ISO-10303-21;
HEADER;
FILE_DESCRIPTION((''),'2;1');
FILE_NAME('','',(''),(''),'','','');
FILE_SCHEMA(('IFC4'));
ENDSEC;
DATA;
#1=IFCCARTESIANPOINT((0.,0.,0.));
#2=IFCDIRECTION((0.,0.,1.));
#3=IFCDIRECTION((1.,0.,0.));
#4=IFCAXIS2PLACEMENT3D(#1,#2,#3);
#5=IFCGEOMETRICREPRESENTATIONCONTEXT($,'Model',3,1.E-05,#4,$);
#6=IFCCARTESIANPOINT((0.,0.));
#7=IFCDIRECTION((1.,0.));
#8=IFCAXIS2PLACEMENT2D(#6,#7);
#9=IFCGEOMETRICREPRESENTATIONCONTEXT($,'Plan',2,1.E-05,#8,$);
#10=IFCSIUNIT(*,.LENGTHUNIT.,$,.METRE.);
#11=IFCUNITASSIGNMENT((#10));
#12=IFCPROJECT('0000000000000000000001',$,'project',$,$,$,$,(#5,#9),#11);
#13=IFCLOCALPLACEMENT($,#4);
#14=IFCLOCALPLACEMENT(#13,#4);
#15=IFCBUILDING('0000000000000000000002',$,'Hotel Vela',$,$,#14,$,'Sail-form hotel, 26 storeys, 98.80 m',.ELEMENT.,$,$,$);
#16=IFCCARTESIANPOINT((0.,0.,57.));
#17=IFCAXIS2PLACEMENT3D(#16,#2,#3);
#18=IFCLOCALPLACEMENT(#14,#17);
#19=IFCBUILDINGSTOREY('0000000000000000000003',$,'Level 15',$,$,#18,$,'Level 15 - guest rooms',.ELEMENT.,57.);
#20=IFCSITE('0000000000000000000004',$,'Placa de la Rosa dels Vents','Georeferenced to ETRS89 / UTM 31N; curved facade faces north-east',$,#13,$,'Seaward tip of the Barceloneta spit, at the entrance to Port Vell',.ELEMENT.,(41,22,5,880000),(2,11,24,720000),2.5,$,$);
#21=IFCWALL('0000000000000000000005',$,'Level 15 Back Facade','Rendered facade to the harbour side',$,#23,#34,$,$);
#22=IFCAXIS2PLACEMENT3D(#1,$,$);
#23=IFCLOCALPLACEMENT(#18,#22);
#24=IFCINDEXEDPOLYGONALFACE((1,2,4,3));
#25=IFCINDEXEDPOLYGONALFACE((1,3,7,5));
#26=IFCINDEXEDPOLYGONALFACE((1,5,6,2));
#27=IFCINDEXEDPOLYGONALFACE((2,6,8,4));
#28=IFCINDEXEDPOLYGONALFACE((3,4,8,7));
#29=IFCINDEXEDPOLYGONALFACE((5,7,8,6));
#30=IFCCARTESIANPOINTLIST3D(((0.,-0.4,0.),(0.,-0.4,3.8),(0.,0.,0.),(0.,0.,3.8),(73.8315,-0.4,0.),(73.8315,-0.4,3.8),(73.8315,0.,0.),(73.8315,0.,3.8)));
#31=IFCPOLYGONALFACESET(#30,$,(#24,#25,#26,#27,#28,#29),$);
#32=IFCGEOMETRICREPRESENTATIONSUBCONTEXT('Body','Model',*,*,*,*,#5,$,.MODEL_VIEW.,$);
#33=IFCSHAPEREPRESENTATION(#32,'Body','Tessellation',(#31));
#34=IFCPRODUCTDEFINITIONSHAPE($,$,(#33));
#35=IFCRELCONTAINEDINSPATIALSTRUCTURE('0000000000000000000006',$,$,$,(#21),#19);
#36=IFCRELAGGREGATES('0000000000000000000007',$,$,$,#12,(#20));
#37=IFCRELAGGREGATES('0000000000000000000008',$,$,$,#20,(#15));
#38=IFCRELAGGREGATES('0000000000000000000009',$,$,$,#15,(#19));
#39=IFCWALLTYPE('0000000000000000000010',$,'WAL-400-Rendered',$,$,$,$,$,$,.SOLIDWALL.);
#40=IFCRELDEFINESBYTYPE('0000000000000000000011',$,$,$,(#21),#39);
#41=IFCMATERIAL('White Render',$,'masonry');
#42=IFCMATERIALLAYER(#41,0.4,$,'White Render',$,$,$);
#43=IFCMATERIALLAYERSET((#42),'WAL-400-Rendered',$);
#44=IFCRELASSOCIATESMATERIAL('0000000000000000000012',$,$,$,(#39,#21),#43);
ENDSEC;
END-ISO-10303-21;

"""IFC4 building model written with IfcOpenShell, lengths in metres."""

from ifc_helpers import new_model, si_unit, frame, origin_with_axes, origin_2d_with_axis, place, context, subcontext, project, spatial, line, indexed_curve, outline, extrude, material, layer, layer_set, layer_usage, type_object, element, save


model = new_model("IFC4")

# Units and contexts
model_context = context("Model", 3, precision=1e-05, world=origin_with_axes())
plan_context = context("Plan", 2, precision=1e-05, world=origin_2d_with_axis())
body_context = subcontext(model_context, "Body", "Model", "MODEL_VIEW")
ifc_project = project(units=[si_unit("LENGTHUNIT", "METRE")], contexts=[model_context, plan_context])

# Site, building, storey
site_placement = place(None, origin_with_axes())
site = spatial("IfcSite", under=ifc_project, at=site_placement, Name="Placa de la Rosa dels Vents", Description="Georeferenced to ETRS89 / UTM 31N; curved facade faces north-east", LongName="Seaward tip of the Barceloneta spit, at the entrance to Port Vell", CompositionType="ELEMENT", RefLatitude=(41, 22, 5, 880000), RefLongitude=(2, 11, 24, 720000), RefElevation=2.5)
building_placement = place(site_placement, origin_with_axes())
building = spatial("IfcBuilding", under=site, at=building_placement, Name="Hotel Vela", LongName="Sail-form hotel, 26 storeys, 98.80 m", CompositionType="ELEMENT")
storey_placement = place(building_placement, frame((0.0, 0.0, 57.0), z_axis=(0.0, 0.0, 1.0), x_axis=(1.0, 0.0, 0.0)))
storey = spatial("IfcBuildingStorey", under=building, at=storey_placement, Name="Level 15", LongName="Level 15 - guest rooms", CompositionType="ELEMENT", Elevation=57.0)

# Wall
ifc_material_1 = material(Name="White Render", Category="masonry")
ifc_layer_1 = layer(ifc_material_1, 0.4, Name="White Render")
ifc_layer_set_1 = layer_set([ifc_layer_1], Name="WAL-400-Rendered")
ifc_layer_usage_1 = layer_usage(ifc_layer_set_1, "AXIS2", "POSITIVE", 0.0)
wall_type = type_object("IfcWallType", Name="WAL-400-Rendered", PredefinedType="SOLIDWALL", material=ifc_layer_set_1)
wall_placement = place(storey_placement, frame((0.0, -0.4, 0.0), z_axis=(0.0, 0.0, 1.0), x_axis=(1.0, 0.0, 0.0)))
element("IfcWall", 1, at=wall_placement, inside=storey, type_object=wall_type, material=ifc_layer_usage_1, Name="Level 15 Back Facade", Description="Rendered facade to the harbour side", context=body_context, shape_type="SweptSolid", body=[
    extrude(outline(indexed_curve([(0.0, 0.0), (73.8315, 0.0), (73.8315, 0.4), (0.0, 0.4)], segments=[line(1, 2, 3, 4, 1)])), origin_with_axes(), (0.0, 0.0, 1.0), 3.8),
])

save(model, "model.ifc")
